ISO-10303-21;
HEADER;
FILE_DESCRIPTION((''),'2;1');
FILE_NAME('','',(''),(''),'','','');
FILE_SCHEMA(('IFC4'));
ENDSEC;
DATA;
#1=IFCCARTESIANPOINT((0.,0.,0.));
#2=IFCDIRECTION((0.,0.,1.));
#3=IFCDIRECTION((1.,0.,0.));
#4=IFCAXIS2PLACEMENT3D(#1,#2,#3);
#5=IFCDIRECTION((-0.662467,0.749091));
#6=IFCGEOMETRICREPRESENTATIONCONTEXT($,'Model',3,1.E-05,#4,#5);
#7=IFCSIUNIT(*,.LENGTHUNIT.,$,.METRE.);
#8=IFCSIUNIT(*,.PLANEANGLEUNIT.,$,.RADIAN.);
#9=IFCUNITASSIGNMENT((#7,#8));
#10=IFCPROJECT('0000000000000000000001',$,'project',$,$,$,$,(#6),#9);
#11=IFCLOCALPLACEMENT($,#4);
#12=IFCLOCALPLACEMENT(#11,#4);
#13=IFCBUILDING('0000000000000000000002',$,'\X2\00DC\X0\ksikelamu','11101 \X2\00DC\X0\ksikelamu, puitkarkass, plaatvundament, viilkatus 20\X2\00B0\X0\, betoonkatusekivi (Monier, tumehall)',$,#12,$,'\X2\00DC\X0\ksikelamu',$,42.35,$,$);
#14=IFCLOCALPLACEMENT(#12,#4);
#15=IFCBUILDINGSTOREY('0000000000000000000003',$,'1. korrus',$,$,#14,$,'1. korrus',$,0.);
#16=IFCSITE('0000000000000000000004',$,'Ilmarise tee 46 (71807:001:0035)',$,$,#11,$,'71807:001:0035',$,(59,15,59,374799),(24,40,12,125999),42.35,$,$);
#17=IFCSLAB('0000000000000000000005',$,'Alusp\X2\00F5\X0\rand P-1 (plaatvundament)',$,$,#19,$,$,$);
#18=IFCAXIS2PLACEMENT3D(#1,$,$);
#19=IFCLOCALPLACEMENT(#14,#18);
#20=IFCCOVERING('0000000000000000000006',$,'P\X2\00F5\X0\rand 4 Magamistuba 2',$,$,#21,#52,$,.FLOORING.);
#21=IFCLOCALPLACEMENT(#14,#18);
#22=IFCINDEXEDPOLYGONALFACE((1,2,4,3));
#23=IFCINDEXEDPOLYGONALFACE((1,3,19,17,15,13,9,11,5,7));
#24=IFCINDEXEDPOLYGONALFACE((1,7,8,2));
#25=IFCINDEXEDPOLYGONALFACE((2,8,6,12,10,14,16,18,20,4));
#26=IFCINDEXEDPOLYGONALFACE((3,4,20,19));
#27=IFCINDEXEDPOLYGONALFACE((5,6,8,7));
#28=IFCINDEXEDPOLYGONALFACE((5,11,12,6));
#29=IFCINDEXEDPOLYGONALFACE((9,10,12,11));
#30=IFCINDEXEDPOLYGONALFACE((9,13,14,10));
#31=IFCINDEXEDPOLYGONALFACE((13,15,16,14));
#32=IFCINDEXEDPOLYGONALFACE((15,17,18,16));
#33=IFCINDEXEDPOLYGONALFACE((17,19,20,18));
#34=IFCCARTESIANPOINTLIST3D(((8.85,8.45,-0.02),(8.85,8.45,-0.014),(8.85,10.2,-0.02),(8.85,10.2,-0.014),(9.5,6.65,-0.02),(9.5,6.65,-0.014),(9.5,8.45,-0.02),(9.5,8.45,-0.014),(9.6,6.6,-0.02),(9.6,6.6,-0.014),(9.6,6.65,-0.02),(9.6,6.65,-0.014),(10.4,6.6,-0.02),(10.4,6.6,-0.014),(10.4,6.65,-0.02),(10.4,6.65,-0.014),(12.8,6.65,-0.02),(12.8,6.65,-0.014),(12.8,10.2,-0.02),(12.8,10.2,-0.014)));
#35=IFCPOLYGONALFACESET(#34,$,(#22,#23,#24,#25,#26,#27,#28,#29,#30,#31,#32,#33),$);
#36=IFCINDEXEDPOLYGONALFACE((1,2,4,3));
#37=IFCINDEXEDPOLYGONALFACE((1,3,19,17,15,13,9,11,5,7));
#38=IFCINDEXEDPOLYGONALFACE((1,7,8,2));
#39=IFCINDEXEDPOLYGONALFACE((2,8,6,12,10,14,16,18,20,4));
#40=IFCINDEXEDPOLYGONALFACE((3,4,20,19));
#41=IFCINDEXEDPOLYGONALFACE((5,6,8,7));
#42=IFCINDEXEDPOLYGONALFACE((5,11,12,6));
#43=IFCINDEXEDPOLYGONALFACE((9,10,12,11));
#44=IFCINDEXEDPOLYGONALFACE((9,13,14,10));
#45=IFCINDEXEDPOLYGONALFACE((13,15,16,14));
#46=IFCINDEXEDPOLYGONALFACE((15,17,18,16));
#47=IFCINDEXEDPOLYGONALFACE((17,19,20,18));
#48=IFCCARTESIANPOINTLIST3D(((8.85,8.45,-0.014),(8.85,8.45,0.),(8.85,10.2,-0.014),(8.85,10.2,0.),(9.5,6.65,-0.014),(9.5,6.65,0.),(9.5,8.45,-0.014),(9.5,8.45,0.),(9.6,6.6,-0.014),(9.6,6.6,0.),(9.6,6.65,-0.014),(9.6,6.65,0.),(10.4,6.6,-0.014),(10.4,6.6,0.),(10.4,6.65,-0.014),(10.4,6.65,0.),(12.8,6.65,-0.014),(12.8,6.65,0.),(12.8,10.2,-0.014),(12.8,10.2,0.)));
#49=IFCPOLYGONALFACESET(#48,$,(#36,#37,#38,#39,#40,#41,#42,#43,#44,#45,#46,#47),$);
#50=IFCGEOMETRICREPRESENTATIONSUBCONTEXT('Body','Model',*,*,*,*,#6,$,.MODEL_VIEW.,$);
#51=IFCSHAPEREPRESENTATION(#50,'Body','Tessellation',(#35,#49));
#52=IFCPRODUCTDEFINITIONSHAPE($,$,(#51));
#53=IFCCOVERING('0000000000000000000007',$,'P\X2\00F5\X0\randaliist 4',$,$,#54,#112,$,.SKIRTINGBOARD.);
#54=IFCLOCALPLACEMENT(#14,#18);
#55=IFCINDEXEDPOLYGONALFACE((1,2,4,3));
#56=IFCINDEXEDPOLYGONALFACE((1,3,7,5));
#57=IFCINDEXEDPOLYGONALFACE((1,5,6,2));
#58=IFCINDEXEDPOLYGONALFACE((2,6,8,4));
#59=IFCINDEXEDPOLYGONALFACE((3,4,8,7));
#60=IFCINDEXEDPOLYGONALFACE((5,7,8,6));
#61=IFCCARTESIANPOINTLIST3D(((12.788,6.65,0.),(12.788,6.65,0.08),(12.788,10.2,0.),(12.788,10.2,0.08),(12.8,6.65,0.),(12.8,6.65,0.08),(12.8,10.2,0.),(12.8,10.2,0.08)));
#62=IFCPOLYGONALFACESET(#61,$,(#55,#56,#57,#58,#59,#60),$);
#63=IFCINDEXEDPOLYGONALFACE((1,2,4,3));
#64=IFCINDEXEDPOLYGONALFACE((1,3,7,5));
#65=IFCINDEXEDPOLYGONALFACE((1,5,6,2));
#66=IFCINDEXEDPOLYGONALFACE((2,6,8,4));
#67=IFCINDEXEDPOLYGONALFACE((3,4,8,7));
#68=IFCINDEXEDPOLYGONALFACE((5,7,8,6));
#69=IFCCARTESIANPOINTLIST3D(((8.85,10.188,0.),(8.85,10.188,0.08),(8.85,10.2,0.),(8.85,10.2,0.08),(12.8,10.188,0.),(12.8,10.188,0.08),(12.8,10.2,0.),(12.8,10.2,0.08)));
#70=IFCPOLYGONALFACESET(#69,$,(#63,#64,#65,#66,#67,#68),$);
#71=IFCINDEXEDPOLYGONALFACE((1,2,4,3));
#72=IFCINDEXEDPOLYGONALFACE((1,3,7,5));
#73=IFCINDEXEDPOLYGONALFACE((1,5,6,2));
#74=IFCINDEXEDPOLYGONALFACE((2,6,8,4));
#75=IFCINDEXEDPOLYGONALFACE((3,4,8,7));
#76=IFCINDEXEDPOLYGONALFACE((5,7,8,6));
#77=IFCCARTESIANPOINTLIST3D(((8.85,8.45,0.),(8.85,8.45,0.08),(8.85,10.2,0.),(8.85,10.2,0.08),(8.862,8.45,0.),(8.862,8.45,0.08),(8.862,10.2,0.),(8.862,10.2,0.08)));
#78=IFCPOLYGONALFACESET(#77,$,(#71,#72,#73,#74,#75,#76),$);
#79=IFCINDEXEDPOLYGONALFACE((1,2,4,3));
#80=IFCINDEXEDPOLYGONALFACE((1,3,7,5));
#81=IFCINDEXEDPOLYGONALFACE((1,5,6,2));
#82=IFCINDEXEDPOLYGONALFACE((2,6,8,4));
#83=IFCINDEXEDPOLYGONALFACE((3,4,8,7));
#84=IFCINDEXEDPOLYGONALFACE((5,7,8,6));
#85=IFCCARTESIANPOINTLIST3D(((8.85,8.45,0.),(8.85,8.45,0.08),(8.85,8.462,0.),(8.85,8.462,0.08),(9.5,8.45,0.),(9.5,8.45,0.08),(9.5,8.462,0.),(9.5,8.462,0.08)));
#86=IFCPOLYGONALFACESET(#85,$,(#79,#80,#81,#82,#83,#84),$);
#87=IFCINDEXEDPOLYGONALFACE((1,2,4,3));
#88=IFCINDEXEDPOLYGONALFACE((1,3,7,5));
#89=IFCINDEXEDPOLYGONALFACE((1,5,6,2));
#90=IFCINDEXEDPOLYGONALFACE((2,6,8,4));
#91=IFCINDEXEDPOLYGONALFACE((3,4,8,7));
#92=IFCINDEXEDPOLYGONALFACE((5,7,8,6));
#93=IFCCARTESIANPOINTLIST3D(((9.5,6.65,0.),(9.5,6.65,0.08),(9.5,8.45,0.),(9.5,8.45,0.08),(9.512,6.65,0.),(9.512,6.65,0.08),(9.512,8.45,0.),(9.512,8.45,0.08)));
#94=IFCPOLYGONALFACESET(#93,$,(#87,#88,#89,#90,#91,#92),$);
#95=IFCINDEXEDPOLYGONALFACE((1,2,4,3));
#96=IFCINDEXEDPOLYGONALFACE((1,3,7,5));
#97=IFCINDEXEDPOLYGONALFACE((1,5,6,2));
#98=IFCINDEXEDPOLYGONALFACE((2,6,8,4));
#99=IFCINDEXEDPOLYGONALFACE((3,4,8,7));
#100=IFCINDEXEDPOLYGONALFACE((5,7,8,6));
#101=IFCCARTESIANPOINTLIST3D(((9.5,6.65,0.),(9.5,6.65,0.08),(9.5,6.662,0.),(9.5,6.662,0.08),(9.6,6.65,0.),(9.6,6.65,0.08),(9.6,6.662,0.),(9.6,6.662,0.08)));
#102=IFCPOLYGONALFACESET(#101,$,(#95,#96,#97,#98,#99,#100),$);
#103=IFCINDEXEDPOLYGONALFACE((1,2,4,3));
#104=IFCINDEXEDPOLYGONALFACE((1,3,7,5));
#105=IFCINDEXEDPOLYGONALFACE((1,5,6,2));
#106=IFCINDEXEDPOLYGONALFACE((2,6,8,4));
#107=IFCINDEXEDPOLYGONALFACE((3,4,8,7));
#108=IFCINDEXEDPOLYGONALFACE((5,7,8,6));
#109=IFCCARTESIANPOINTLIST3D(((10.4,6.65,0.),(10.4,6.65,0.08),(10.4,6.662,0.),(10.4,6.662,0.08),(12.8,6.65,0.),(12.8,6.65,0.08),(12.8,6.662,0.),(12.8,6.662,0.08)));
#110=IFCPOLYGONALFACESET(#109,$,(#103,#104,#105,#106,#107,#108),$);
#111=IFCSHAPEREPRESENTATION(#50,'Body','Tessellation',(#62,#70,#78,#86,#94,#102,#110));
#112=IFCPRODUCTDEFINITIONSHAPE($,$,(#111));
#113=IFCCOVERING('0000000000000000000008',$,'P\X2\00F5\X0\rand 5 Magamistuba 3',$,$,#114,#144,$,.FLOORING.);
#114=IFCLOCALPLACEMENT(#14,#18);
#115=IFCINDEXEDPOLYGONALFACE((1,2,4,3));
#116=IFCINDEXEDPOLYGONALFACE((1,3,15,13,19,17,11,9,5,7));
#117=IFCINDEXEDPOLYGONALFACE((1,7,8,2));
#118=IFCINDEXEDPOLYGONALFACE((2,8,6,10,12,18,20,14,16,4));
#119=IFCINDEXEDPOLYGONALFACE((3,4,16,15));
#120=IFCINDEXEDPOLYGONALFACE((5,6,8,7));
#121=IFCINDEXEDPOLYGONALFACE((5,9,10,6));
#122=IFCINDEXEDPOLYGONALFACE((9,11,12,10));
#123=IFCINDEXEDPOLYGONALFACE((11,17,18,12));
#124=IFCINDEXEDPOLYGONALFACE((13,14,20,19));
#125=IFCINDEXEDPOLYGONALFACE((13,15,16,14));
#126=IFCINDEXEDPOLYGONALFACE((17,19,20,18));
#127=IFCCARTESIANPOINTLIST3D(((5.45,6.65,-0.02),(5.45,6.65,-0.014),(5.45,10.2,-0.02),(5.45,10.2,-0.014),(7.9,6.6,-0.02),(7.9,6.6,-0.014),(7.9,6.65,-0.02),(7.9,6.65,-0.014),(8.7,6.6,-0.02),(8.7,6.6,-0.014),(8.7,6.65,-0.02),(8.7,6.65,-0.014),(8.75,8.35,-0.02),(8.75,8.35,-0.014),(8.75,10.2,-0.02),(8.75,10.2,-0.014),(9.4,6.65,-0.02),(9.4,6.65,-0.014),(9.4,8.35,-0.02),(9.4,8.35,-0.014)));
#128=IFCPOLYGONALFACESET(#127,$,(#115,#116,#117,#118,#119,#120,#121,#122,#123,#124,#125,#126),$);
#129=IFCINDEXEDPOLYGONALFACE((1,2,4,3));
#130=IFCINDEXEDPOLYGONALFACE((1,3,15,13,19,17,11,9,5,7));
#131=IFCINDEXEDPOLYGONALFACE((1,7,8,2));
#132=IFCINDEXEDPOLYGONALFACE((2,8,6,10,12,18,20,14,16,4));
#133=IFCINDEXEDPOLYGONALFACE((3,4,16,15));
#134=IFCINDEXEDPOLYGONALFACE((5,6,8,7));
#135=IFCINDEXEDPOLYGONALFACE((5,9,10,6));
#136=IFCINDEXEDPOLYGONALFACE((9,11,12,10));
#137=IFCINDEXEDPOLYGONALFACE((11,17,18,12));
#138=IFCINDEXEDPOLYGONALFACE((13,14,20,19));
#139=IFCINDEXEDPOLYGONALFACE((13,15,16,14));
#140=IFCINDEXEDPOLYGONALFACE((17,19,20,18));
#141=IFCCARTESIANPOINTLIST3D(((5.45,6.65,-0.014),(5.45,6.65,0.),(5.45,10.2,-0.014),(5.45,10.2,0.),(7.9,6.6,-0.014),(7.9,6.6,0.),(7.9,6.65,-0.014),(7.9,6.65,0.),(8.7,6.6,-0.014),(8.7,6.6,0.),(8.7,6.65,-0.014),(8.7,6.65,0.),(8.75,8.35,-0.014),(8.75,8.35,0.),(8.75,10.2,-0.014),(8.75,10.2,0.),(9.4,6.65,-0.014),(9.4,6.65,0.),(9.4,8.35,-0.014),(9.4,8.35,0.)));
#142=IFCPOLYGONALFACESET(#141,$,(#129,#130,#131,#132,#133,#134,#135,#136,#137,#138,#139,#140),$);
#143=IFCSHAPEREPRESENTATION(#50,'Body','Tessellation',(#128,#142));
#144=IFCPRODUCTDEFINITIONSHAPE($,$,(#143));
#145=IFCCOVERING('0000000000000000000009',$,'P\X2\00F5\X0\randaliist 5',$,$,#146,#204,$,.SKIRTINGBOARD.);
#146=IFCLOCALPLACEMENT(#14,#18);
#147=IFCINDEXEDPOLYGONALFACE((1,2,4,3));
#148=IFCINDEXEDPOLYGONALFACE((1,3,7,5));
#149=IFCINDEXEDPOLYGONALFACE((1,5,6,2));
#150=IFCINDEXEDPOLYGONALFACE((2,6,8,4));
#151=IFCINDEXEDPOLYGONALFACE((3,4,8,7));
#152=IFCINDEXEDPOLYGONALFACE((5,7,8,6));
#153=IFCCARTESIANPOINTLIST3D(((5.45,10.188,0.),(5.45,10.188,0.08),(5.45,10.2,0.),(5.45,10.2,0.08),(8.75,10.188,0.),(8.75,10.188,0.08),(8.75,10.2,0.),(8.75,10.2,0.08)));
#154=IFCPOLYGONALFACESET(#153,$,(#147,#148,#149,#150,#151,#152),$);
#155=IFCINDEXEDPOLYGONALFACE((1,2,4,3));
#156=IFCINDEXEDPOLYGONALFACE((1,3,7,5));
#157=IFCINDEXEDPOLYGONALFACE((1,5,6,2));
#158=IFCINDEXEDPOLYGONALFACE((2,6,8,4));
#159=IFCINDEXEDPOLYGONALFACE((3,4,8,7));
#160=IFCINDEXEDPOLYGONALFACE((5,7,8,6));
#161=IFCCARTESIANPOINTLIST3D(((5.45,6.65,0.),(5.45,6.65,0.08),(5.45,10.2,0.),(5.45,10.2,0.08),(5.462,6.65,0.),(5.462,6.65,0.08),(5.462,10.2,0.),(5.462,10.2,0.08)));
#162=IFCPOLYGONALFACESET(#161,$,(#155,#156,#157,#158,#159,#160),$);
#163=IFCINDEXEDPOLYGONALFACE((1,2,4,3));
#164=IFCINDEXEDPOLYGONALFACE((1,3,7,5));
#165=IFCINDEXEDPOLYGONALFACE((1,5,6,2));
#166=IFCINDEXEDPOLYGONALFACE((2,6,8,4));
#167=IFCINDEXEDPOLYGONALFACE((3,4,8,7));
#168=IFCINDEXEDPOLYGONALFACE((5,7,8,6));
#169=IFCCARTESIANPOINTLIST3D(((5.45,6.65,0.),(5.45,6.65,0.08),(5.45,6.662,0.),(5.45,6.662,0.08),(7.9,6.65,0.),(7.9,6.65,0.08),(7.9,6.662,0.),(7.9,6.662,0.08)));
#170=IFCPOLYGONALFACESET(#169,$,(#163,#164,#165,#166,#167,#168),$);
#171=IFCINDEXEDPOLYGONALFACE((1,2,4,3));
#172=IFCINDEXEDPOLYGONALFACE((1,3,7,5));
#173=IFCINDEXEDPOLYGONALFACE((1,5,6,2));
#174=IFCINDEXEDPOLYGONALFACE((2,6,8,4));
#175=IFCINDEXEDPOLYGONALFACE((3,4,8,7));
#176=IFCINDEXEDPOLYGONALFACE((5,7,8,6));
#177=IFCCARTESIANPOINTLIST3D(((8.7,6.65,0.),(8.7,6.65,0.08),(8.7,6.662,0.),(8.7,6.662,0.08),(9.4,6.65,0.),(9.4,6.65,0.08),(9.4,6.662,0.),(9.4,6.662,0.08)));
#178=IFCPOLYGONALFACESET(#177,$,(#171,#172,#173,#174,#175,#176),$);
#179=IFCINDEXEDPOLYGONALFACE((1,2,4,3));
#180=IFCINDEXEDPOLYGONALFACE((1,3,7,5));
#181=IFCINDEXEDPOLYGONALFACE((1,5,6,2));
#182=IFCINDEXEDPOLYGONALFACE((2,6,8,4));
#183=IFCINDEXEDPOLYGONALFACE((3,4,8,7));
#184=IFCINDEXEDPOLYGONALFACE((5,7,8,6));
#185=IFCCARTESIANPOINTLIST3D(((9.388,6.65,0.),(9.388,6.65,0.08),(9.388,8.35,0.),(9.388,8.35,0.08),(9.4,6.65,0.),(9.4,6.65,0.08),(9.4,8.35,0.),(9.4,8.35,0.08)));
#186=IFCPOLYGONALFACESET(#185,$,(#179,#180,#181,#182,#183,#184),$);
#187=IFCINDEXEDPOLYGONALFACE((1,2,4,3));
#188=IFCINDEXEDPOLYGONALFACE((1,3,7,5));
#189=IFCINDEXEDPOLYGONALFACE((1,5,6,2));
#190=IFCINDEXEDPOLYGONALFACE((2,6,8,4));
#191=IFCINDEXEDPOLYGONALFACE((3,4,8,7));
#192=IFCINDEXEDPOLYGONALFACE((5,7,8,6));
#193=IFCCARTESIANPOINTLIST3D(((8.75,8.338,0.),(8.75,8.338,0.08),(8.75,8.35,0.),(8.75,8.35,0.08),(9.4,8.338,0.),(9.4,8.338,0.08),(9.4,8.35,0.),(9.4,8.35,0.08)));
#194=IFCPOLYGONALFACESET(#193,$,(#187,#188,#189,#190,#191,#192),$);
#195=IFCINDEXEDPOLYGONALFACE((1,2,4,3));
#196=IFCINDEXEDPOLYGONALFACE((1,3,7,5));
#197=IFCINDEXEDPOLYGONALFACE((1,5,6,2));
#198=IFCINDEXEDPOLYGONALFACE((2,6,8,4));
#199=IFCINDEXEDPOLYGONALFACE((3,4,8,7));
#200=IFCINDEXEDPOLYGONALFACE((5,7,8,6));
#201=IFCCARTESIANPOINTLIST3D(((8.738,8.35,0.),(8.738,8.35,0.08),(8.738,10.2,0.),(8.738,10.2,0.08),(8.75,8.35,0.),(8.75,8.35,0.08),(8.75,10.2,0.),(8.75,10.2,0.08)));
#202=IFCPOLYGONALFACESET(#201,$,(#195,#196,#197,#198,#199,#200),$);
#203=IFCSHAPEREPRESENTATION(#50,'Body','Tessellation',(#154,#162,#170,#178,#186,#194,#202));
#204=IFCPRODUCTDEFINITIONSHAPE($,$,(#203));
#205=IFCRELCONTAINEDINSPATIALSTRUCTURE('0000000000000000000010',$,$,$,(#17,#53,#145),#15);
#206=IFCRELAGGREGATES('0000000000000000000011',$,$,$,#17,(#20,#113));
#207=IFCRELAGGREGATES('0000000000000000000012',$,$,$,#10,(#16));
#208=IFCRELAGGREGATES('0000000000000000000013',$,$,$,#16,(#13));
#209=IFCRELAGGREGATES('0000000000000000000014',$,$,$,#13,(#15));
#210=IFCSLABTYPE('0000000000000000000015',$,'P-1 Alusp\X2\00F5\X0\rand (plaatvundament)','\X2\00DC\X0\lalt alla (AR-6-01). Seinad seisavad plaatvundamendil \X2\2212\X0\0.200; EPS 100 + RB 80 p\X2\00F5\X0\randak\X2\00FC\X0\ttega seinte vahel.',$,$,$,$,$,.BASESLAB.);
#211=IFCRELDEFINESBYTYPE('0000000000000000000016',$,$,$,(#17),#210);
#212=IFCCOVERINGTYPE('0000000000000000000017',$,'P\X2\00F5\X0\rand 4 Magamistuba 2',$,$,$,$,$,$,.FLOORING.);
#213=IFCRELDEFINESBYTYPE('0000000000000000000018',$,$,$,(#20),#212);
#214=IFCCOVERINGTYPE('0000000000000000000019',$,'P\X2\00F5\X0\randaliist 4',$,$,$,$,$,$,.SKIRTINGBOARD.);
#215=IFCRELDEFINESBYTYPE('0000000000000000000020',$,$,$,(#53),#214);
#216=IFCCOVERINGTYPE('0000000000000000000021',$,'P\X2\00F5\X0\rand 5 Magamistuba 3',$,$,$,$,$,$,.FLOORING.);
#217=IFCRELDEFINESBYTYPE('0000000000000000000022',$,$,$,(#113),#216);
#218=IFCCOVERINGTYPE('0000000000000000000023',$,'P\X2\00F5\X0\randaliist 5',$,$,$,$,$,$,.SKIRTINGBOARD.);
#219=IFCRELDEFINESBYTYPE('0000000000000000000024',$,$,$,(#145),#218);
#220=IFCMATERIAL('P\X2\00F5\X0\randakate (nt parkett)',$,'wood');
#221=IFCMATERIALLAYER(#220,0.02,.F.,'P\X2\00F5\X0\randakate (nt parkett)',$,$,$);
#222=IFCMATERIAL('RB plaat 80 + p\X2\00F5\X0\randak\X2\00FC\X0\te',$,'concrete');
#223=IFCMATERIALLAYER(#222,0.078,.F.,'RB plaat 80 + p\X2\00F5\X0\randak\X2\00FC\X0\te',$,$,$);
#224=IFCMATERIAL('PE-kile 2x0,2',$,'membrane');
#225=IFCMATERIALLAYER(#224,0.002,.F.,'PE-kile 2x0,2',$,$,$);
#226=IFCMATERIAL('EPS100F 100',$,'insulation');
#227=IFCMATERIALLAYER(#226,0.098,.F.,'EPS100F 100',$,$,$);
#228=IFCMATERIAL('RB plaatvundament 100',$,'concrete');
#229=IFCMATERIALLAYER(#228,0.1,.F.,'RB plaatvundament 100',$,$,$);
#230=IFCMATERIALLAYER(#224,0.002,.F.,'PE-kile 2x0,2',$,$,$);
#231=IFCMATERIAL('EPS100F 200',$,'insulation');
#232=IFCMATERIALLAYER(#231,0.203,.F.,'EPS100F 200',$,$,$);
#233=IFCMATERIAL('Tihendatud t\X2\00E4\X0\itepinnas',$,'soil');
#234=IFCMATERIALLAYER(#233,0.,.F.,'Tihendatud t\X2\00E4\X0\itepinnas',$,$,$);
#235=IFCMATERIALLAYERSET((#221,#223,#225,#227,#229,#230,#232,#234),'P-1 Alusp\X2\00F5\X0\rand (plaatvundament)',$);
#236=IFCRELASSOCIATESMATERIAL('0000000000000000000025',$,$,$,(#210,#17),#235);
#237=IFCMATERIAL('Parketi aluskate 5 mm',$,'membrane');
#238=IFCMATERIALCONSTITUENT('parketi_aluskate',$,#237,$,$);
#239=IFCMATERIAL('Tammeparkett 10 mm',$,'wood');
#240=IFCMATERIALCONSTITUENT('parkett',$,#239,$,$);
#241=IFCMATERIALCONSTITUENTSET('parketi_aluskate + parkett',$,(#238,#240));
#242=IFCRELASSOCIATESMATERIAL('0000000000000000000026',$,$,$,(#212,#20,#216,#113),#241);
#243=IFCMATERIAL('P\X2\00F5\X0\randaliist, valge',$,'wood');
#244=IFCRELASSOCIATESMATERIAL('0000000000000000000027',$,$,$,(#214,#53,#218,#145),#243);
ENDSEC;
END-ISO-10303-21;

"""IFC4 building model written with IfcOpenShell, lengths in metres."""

from ifc_helpers import new_model, si_unit, direction, frame, origin_with_axes, place, context, subcontext, project, spatial, indexed_curve, outline, extrude, material, layer, layer_set, layer_usage, constituent, constituent_set, type_object, element, aggregate, save


model = new_model("IFC4")

# Units and contexts
model_context = context("Model", 3, precision=1e-05, world=origin_with_axes(), true_north=direction((-0.662467, 0.749091)))
body_context = subcontext(model_context, "Body", "Model", "MODEL_VIEW")
ifc_project = project(units=[si_unit("LENGTHUNIT", "METRE"), si_unit("PLANEANGLEUNIT", "RADIAN")], contexts=[model_context])

# Site, building, storey
site_placement = place(None, origin_with_axes())
site = spatial("IfcSite", under=ifc_project, at=site_placement, Name="Ilmarise tee 46 (71807:001:0035)", LongName="71807:001:0035", RefLatitude=(59, 15, 59, 374799), RefLongitude=(24, 40, 12, 125999), RefElevation=42.35)
building_placement = place(site_placement, origin_with_axes())
building = spatial("IfcBuilding", under=site, at=building_placement, Name="Üksikelamu", Description="11101 Üksikelamu, puitkarkass, plaatvundament, viilkatus 20°, betoonkatusekivi (Monier, tumehall)", LongName="Üksikelamu", ElevationOfRefHeight=42.35)
storey_placement = place(building_placement, origin_with_axes())
storey = spatial("IfcBuildingStorey", under=building, at=storey_placement, Name="1. korrus", LongName="1. korrus", Elevation=0.0)

# Slab
ifc_material_1 = material(Name="Põrandakate (nt parkett)", Category="wood")
ifc_layer_1 = layer(ifc_material_1, 0.02, ventilated=False, Name="Põrandakate (nt parkett)")
ifc_material_2 = material(Name="RB plaat 80 + põrandaküte", Category="concrete")
ifc_layer_2 = layer(ifc_material_2, 0.078, ventilated=False, Name="RB plaat 80 + põrandaküte")
ifc_material_3 = material(Name="PE-kile 2x0,2", Category="membrane")
ifc_layer_3 = layer(ifc_material_3, 0.002, ventilated=False, Name="PE-kile 2x0,2")
ifc_material_4 = material(Name="EPS100F 100", Category="insulation")
ifc_layer_4 = layer(ifc_material_4, 0.098, ventilated=False, Name="EPS100F 100")
ifc_material_5 = material(Name="RB plaatvundament 100", Category="concrete")
ifc_layer_5 = layer(ifc_material_5, 0.1, ventilated=False, Name="RB plaatvundament 100")
ifc_layer_6 = layer(ifc_material_3, 0.002, ventilated=False, Name="PE-kile 2x0,2")
ifc_material_6 = material(Name="EPS100F 200", Category="insulation")
ifc_layer_7 = layer(ifc_material_6, 0.203, ventilated=False, Name="EPS100F 200")
ifc_material_7 = material(Name="Tihendatud täitepinnas", Category="soil")
ifc_layer_8 = layer(ifc_material_7, 0.0, ventilated=False, Name="Tihendatud täitepinnas")
ifc_layer_set_1 = layer_set([ifc_layer_1, ifc_layer_2, ifc_layer_3, ifc_layer_4, ifc_layer_5, ifc_layer_6, ifc_layer_7, ifc_layer_8], Name="P-1 Aluspõrand (plaatvundament)")
ifc_layer_usage_1 = layer_usage(ifc_layer_set_1, "AXIS3", "NEGATIVE", 0.0)
slab_type = type_object("IfcSlabType", Name="P-1 Aluspõrand (plaatvundament)", Description="Ülalt alla (AR-6-01). Seinad seisavad plaatvundamendil −0.200; EPS 100 + RB 80 põrandaküttega seinte vahel.", PredefinedType="BASESLAB", material=ifc_layer_set_1)
slab_placement = place(storey_placement, origin_with_axes())
slab = element("IfcSlab", 1, at=slab_placement, inside=storey, type_object=slab_type, material=ifc_layer_usage_1, Name="Aluspõrand P-1 (plaatvundament)")
ifc_material_8 = material(Name="Parketi aluskate 5 mm", Category="membrane")

# Coverings
ifc_material_9 = material(Name="Põrandaliist, valge", Category="wood")
ifc_constituent_1 = constituent(ifc_material_8, Name="parketi_aluskate")
ifc_material_10 = material(Name="Tammeparkett 10 mm", Category="wood")
ifc_constituent_2 = constituent(ifc_material_10, Name="parkett")
ifc_constituent_set_1 = constituent_set(constituents=[ifc_constituent_1, ifc_constituent_2], Name="parketi_aluskate + parkett")
covering_type_1 = type_object("IfcCoveringType", Name="Põrand 4 Magamistuba 2", PredefinedType="FLOORING", material=ifc_constituent_set_1)
covering_1_placement = place(slab_placement, origin_with_axes())
covering_1 = element("IfcCovering", 2, at=covering_1_placement, type_object=covering_type_1, material=ifc_constituent_set_1, Name="Põrand 4 Magamistuba 2", PredefinedType="FLOORING", context=body_context, shape_type="SweptSolid", body=[
    extrude(outline(indexed_curve([(10.4, 6.65), (10.4, 6.6), (9.6, 6.6), (9.6, 6.65), (9.5, 6.65), (9.5, 8.45), (8.85, 8.45), (8.85, 10.2), (12.8, 10.2), (12.8, 6.65), (10.4, 6.65)], self_intersect=False)), frame((0.0, 0.0, -0.02), z_axis=(0.0, 0.0, 1.0), x_axis=(1.0, 0.0, 0.0)), (0.0, 0.0, 1.0), 0.006),
    extrude(outline(indexed_curve([(10.4, 6.65), (10.4, 6.6), (9.6, 6.6), (9.6, 6.65), (9.5, 6.65), (9.5, 8.45), (8.85, 8.45), (8.85, 10.2), (12.8, 10.2), (12.8, 6.65), (10.4, 6.65)], self_intersect=False)), frame((0.0, 0.0, -0.014), z_axis=(0.0, 0.0, 1.0), x_axis=(1.0, 0.0, 0.0)), (0.0, 0.0, 1.0), 0.014),
])
covering_type_2 = type_object("IfcCoveringType", Name="Põrandaliist 4", PredefinedType="SKIRTINGBOARD", material=ifc_material_9)
covering_2_placement = place(storey_placement, origin_with_axes())
element("IfcCovering", 3, at=covering_2_placement, inside=storey, type_object=covering_type_2, material=ifc_material_9, Name="Põrandaliist 4", PredefinedType="SKIRTINGBOARD", context=body_context, shape_type="SweptSolid", body=[
    extrude(outline(indexed_curve([(12.788, 6.65), (12.788, 10.2), (12.8, 10.2), (12.8, 6.65), (12.788, 6.65)], self_intersect=False)), origin_with_axes(), (0.0, 0.0, 1.0), 0.08),
    extrude(outline(indexed_curve([(12.8, 10.188), (8.85, 10.188), (8.85, 10.2), (12.8, 10.2), (12.8, 10.188)], self_intersect=False)), origin_with_axes(), (0.0, 0.0, 1.0), 0.08),
    extrude(outline(indexed_curve([(8.862, 10.2), (8.862, 8.45), (8.85, 8.45), (8.85, 10.2), (8.862, 10.2)], self_intersect=False)), origin_with_axes(), (0.0, 0.0, 1.0), 0.08),
    extrude(outline(indexed_curve([(8.85, 8.462), (9.5, 8.462), (9.5, 8.45), (8.85, 8.45), (8.85, 8.462)], self_intersect=False)), origin_with_axes(), (0.0, 0.0, 1.0), 0.08),
    extrude(outline(indexed_curve([(9.512, 8.45), (9.512, 6.65), (9.5, 6.65), (9.5, 8.45), (9.512, 8.45)], self_intersect=False)), origin_with_axes(), (0.0, 0.0, 1.0), 0.08),
    extrude(outline(indexed_curve([(9.5, 6.65), (9.5, 6.662), (9.6, 6.662), (9.6, 6.65), (9.5, 6.65)], self_intersect=False)), origin_with_axes(), (0.0, 0.0, 1.0), 0.08),
    extrude(outline(indexed_curve([(12.8, 6.662), (12.8, 6.65), (10.4, 6.65), (10.4, 6.662), (12.8, 6.662)], self_intersect=False)), origin_with_axes(), (0.0, 0.0, 1.0), 0.08),
])
covering_type_3 = type_object("IfcCoveringType", Name="Põrand 5 Magamistuba 3", PredefinedType="FLOORING", material=ifc_constituent_set_1)
covering_3_placement = place(slab_placement, origin_with_axes())
covering_3 = element("IfcCovering", 4, at=covering_3_placement, type_object=covering_type_3, material=ifc_constituent_set_1, Name="Põrand 5 Magamistuba 3", PredefinedType="FLOORING", context=body_context, shape_type="SweptSolid", body=[
    extrude(outline(indexed_curve([(8.75, 8.35), (9.4, 8.35), (9.4, 6.65), (8.7, 6.65), (8.7, 6.6), (7.9, 6.6), (7.9, 6.65), (5.45, 6.65), (5.45, 10.2), (8.75, 10.2), (8.75, 8.35)], self_intersect=False)), frame((0.0, 0.0, -0.02), z_axis=(0.0, 0.0, 1.0), x_axis=(1.0, 0.0, 0.0)), (0.0, 0.0, 1.0), 0.006),
    extrude(outline(indexed_curve([(8.75, 8.35), (9.4, 8.35), (9.4, 6.65), (8.7, 6.65), (8.7, 6.6), (7.9, 6.6), (7.9, 6.65), (5.45, 6.65), (5.45, 10.2), (8.75, 10.2), (8.75, 8.35)], self_intersect=False)), frame((0.0, 0.0, -0.014), z_axis=(0.0, 0.0, 1.0), x_axis=(1.0, 0.0, 0.0)), (0.0, 0.0, 1.0), 0.014),
])
covering_type_4 = type_object("IfcCoveringType", Name="Põrandaliist 5", PredefinedType="SKIRTINGBOARD", material=ifc_material_9)
covering_4_placement = place(storey_placement, origin_with_axes())
element("IfcCovering", 5, at=covering_4_placement, inside=storey, type_object=covering_type_4, material=ifc_material_9, Name="Põrandaliist 5", PredefinedType="SKIRTINGBOARD", context=body_context, shape_type="SweptSolid", body=[
    extrude(outline(indexed_curve([(8.75, 10.188), (5.45, 10.188), (5.45, 10.2), (8.75, 10.2), (8.75, 10.188)], self_intersect=False)), origin_with_axes(), (0.0, 0.0, 1.0), 0.08),
    extrude(outline(indexed_curve([(5.462, 10.2), (5.462, 6.65), (5.45, 6.65), (5.45, 10.2), (5.462, 10.2)], self_intersect=False)), origin_with_axes(), (0.0, 0.0, 1.0), 0.08),
    extrude(outline(indexed_curve([(5.45, 6.65), (5.45, 6.662), (7.9, 6.662), (7.9, 6.65), (5.45, 6.65)], self_intersect=False)), origin_with_axes(), (0.0, 0.0, 1.0), 0.08),
    extrude(outline(indexed_curve([(9.4, 6.662), (9.4, 6.65), (8.7, 6.65), (8.7, 6.662), (9.4, 6.662)], self_intersect=False)), origin_with_axes(), (0.0, 0.0, 1.0), 0.08),
    extrude(outline(indexed_curve([(9.388, 6.65), (9.388, 8.35), (9.4, 8.35), (9.4, 6.65), (9.388, 6.65)], self_intersect=False)), origin_with_axes(), (0.0, 0.0, 1.0), 0.08),
    extrude(outline(indexed_curve([(9.4, 8.338), (8.75, 8.338), (8.75, 8.35), (9.4, 8.35), (9.4, 8.338)], self_intersect=False)), origin_with_axes(), (0.0, 0.0, 1.0), 0.08),
    extrude(outline(indexed_curve([(8.738, 8.35), (8.738, 10.2), (8.75, 10.2), (8.75, 8.35), (8.738, 8.35)], self_intersect=False)), origin_with_axes(), (0.0, 0.0, 1.0), 0.08),
])

aggregate(slab, [covering_1, covering_3])

save(model, "model.ifc")
